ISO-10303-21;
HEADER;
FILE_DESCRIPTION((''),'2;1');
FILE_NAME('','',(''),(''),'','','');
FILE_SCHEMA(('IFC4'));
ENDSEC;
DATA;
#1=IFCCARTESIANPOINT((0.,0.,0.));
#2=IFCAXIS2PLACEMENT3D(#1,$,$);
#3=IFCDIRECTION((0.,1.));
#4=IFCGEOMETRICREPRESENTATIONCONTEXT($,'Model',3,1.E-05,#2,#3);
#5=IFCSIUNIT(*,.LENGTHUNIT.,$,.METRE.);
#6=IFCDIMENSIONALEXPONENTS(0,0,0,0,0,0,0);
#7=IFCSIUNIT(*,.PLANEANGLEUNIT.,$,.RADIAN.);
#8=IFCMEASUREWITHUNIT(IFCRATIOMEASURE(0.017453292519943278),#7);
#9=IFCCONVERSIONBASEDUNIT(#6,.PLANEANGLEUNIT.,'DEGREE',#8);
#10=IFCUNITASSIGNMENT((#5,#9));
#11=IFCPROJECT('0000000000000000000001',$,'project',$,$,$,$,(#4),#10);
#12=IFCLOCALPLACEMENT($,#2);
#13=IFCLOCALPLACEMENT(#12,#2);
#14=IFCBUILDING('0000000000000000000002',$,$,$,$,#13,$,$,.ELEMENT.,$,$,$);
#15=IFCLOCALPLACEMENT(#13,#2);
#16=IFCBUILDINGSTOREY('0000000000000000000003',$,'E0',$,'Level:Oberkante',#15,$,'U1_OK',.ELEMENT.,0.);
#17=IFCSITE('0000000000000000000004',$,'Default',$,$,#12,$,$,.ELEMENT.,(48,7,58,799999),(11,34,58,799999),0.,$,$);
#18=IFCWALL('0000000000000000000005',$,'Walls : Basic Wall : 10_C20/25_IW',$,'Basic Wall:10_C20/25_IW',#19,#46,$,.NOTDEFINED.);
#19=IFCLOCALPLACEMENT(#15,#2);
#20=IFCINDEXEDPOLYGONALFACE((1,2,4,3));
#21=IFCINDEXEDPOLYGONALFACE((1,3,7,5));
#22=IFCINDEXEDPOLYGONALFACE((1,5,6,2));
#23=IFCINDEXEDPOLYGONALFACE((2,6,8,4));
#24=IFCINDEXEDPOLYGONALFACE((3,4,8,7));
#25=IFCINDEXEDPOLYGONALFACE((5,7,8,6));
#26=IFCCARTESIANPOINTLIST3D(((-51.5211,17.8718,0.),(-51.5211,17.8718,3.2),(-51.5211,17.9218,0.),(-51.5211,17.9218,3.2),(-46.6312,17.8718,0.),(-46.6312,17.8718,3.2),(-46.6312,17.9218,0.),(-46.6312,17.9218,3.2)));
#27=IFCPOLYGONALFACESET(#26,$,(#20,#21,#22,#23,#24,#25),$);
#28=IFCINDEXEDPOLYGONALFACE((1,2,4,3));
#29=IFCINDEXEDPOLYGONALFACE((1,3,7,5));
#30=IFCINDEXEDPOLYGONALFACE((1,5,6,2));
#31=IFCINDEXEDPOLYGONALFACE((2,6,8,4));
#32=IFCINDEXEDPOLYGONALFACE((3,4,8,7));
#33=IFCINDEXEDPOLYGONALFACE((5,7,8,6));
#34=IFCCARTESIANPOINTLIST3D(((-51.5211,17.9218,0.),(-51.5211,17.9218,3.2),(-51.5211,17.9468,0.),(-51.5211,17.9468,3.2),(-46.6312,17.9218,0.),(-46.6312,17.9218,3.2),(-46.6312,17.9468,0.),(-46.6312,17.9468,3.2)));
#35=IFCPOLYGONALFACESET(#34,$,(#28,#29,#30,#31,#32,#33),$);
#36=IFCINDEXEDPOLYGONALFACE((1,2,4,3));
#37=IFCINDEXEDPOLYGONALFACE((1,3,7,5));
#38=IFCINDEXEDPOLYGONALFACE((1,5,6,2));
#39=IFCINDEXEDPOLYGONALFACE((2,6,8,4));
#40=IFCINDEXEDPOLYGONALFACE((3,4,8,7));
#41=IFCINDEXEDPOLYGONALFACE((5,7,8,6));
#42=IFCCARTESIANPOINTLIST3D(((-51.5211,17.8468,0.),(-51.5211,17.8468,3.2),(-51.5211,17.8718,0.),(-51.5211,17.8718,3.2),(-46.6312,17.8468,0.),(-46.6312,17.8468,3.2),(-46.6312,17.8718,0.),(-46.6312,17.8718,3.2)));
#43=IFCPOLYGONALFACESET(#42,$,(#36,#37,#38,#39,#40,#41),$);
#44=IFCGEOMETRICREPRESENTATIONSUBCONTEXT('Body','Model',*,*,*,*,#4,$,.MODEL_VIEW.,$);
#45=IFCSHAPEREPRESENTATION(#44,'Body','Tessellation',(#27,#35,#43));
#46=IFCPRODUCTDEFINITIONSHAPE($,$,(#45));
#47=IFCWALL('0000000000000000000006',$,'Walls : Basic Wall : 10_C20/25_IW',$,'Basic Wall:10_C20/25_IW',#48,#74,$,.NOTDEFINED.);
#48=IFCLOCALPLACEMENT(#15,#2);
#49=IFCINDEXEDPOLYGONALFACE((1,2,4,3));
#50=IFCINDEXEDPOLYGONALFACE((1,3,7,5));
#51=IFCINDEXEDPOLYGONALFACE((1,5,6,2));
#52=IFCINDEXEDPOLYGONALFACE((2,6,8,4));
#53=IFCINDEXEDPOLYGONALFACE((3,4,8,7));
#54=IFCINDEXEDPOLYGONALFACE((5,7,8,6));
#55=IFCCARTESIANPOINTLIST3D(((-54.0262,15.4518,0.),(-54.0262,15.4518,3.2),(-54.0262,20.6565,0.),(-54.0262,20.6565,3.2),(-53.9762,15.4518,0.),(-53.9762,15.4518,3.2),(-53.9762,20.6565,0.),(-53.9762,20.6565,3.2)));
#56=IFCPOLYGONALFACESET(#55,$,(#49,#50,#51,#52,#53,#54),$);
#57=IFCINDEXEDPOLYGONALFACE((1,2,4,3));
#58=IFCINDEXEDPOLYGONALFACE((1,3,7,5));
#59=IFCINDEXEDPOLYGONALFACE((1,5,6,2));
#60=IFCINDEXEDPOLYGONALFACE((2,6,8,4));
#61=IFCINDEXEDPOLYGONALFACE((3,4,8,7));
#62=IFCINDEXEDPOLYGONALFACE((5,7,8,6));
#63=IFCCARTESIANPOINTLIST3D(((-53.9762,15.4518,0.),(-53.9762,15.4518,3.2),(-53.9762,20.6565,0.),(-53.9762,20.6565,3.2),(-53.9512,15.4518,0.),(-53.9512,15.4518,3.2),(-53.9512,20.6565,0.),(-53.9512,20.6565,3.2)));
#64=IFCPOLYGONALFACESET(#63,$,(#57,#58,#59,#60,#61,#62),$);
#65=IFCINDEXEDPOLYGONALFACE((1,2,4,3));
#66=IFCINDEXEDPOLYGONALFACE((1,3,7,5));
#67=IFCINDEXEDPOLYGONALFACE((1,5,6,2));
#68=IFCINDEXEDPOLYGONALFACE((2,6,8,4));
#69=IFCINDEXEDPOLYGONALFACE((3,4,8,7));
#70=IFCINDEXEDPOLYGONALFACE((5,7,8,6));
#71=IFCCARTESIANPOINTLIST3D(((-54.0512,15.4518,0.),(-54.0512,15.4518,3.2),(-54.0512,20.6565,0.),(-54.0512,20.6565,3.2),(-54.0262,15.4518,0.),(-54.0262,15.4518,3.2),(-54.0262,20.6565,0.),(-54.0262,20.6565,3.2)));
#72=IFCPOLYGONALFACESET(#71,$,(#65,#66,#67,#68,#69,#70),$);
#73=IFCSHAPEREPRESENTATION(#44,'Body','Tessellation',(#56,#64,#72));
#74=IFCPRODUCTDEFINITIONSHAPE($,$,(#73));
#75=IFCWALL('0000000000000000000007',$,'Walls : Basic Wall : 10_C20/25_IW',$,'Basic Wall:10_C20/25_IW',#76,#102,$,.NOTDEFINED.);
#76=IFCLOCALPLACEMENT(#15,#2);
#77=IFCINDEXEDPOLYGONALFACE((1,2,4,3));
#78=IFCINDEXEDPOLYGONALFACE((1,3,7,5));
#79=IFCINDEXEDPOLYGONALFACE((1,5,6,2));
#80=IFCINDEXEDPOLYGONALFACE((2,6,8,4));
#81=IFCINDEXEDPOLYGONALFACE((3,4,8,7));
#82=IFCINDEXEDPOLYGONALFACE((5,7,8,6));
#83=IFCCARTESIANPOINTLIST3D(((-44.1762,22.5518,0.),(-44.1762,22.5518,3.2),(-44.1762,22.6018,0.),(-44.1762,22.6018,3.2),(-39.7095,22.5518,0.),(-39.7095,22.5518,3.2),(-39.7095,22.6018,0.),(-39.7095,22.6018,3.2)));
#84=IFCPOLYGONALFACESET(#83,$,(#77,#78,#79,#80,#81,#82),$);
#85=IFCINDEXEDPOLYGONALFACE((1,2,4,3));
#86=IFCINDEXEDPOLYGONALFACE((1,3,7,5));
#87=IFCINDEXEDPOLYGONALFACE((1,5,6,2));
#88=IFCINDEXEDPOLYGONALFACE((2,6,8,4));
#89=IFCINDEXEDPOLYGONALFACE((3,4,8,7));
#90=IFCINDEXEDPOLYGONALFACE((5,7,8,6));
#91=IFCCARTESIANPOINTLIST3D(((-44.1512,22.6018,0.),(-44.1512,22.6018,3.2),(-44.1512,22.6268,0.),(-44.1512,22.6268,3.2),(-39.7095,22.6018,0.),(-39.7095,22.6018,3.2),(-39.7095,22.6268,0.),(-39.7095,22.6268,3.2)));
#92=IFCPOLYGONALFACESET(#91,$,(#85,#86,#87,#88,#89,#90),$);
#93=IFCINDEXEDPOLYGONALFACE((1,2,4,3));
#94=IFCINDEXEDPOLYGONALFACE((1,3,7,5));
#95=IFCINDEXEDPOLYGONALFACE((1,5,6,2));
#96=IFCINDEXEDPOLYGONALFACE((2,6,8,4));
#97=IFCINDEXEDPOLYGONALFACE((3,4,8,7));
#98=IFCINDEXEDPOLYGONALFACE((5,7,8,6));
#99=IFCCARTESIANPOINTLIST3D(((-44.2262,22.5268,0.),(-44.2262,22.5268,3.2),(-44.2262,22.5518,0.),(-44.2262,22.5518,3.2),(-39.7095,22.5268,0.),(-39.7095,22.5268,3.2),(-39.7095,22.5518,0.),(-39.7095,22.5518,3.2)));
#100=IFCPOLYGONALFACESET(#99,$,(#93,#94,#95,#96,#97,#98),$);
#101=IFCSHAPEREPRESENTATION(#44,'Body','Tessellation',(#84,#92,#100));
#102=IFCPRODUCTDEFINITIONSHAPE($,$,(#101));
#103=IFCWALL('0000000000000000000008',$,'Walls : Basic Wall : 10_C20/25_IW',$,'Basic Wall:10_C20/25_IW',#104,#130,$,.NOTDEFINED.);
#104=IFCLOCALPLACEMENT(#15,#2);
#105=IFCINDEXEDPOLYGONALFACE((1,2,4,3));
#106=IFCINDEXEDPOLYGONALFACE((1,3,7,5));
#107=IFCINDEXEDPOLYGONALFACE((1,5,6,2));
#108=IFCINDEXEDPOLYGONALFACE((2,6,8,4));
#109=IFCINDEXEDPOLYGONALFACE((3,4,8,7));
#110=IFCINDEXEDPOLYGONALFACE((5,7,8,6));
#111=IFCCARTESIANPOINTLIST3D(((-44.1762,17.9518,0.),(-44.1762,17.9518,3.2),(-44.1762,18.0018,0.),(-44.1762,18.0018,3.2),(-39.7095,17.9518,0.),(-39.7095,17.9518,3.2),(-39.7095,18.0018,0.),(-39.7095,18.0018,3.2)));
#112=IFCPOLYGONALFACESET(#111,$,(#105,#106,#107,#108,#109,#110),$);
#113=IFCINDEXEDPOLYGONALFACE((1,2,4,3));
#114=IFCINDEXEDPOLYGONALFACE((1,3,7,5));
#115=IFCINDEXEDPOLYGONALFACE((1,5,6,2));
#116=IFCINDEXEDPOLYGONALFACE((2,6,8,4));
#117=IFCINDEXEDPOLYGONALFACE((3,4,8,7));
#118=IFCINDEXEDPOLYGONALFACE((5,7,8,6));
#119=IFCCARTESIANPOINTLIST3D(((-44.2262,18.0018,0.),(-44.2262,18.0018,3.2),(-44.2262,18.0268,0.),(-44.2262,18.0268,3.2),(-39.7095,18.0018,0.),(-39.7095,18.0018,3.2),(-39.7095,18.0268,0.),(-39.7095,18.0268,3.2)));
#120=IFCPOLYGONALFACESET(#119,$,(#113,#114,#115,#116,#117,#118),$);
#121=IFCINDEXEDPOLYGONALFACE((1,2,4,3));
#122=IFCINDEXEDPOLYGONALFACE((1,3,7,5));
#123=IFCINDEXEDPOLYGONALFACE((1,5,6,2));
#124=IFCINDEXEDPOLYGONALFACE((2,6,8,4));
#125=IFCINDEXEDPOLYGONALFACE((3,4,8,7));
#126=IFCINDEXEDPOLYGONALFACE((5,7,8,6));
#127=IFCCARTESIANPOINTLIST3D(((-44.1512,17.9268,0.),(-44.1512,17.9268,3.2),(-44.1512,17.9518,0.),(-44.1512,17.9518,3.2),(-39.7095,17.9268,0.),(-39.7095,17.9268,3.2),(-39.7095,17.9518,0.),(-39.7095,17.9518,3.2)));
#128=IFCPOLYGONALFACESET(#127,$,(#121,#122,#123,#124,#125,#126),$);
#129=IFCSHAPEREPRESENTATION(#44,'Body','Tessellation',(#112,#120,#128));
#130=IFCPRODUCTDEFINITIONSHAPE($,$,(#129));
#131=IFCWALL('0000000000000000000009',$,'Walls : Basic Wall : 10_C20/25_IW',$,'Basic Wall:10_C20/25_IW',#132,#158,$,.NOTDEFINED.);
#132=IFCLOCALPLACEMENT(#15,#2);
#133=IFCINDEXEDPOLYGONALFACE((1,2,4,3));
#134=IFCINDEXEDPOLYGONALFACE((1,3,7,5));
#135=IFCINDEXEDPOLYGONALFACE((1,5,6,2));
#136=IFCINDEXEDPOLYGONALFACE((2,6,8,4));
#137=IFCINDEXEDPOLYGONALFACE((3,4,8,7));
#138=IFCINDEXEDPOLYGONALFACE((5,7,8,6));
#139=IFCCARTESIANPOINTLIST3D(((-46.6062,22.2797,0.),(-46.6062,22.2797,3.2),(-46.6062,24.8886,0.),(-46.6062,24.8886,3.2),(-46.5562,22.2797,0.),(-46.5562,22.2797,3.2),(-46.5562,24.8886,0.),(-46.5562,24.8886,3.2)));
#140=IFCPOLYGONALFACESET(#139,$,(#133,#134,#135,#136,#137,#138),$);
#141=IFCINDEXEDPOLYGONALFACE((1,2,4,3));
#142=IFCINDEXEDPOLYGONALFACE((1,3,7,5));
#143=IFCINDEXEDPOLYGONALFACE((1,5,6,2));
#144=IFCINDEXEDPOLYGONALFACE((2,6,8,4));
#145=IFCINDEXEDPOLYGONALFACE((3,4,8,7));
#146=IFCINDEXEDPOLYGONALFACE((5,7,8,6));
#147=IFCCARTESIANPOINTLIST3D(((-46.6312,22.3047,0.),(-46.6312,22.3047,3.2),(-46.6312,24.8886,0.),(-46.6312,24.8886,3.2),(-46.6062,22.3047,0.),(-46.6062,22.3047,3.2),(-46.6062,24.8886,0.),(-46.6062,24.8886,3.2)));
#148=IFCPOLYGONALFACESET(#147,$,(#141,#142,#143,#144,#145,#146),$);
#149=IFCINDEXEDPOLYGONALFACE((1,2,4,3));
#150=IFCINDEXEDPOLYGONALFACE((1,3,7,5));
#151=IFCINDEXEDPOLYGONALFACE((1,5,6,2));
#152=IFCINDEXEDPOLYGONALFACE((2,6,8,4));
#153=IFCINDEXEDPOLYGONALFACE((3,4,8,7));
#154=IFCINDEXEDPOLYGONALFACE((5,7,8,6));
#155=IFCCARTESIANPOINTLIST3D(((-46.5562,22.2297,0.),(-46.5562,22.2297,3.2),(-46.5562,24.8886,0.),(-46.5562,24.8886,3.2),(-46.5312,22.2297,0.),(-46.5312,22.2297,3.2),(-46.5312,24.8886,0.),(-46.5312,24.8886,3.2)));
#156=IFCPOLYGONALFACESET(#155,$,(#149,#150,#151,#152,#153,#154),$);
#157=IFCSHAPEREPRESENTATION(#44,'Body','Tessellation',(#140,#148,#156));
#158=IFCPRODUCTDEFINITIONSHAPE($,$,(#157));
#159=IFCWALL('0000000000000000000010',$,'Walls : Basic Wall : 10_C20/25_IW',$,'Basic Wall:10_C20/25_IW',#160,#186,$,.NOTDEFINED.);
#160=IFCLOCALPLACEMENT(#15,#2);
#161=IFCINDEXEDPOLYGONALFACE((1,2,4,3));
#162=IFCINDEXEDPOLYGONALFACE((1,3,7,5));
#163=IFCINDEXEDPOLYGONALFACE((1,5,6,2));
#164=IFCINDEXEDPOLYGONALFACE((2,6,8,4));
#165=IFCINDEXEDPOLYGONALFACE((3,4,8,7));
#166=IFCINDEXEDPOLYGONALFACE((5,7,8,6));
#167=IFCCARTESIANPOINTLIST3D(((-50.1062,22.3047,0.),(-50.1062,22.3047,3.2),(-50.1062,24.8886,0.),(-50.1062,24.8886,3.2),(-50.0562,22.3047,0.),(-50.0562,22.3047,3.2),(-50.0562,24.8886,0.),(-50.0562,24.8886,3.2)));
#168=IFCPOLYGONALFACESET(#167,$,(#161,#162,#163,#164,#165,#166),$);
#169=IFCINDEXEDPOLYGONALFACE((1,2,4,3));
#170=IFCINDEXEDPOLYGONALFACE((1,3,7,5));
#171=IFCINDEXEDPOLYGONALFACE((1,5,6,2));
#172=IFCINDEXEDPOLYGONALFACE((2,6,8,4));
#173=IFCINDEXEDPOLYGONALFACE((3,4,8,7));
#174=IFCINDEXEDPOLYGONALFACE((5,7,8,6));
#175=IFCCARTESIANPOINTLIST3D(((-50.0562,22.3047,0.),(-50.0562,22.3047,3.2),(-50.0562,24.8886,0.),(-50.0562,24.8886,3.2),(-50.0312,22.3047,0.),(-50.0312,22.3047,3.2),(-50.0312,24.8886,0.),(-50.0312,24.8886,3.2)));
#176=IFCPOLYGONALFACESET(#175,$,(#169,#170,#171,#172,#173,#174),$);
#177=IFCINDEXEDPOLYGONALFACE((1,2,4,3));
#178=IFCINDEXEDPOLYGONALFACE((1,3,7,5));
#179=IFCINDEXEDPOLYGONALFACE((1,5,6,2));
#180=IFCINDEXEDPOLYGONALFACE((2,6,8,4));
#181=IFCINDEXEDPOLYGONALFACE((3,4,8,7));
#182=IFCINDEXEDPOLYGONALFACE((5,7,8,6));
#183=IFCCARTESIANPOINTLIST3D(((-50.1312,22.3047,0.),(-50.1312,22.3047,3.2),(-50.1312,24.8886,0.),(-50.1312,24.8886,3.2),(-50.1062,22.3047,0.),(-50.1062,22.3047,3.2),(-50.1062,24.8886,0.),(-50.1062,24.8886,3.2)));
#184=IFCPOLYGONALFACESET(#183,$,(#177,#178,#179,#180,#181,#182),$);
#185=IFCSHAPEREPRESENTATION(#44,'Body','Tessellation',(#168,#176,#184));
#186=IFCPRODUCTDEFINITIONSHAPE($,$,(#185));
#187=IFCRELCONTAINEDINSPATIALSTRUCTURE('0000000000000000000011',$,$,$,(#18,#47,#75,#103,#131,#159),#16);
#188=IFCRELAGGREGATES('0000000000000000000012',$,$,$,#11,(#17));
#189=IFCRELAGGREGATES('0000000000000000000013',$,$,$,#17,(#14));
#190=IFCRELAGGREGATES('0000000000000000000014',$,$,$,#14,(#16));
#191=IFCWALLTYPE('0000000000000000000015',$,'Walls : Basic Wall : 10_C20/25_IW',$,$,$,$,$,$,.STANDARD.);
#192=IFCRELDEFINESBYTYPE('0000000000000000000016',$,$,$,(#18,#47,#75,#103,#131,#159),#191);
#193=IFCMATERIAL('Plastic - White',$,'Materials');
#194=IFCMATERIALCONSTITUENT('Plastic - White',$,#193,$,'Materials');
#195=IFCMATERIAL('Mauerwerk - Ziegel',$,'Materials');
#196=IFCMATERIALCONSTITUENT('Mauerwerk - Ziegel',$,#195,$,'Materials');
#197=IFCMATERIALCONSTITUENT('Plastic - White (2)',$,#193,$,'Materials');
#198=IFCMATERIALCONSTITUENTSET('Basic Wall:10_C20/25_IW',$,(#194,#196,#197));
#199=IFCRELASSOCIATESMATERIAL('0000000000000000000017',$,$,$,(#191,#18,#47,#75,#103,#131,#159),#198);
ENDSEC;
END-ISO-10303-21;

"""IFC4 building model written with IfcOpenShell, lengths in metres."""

from ifc_helpers import new_model, entity, si_unit, converted_unit, direction, frame, origin, place, context, subcontext, project, spatial, indexed_curve, outline, extrude, material, constituent, constituent_set, type_object, element, save


model = new_model("IFC4")

# Units and contexts
model_context = context("Model", 3, precision=1e-05, world=origin(), true_north=direction((0.0, 1.0)))
body_context = subcontext(model_context, "Body", "Model", "MODEL_VIEW")
ifc_project = project(units=[si_unit("LENGTHUNIT", "METRE"), converted_unit("PLANEANGLEUNIT", "DEGREE", entity("IfcRatioMeasure", 0.017453292519943278), si_unit("PLANEANGLEUNIT", "RADIAN"), dimensions=[0, 0, 0, 0, 0, 0, 0])], contexts=[model_context])

# Site, building, storey
site_placement = place(None, origin())
site = spatial("IfcSite", under=ifc_project, at=site_placement, Name="Default", CompositionType="ELEMENT", RefLatitude=(48, 7, 58, 799999), RefLongitude=(11, 34, 58, 799999), RefElevation=0.0)
building_placement = place(site_placement, origin())
building = spatial("IfcBuilding", under=site, at=building_placement, CompositionType="ELEMENT")
storey_placement = place(building_placement, origin())
storey = spatial("IfcBuildingStorey", under=building, at=storey_placement, Name="E0", ObjectType="Level:Oberkante", LongName="U1_OK", CompositionType="ELEMENT", Elevation=0.0)

# Wall
ifc_material_1 = material(Name="Plastic - White", Category="Materials")
ifc_constituent_1 = constituent(ifc_material_1, Name="Plastic - White", Category="Materials")
ifc_material_2 = material(Name="Mauerwerk - Ziegel", Category="Materials")
ifc_constituent_2 = constituent(ifc_material_2, Name="Mauerwerk - Ziegel", Category="Materials")
ifc_constituent_3 = constituent(ifc_material_1, Name="Plastic - White (2)", Category="Materials")
ifc_constituent_set_1 = constituent_set(constituents=[ifc_constituent_1, ifc_constituent_2, ifc_constituent_3], Name="Basic Wall:10_C20/25_IW")
wall_type_1 = type_object("IfcWallType", Name="Walls : Basic Wall : 10_C20/25_IW", PredefinedType="STANDARD", material=ifc_constituent_set_1)
wall_1_placement = place(storey_placement, frame((-51.5211, 17.8968, 0.0)))
element("IfcWall", 1, at=wall_1_placement, inside=storey, type_object=wall_type_1, material=ifc_constituent_set_1, Name="Walls : Basic Wall : 10_C20/25_IW", ObjectType="Basic Wall:10_C20/25_IW", PredefinedType="NOTDEFINED", context=body_context, shape_type="SweptSolid", body=[
    extrude(outline(indexed_curve([(-2.4449, -0.025), (2.4449, -0.025), (2.4449, 0.025), (-2.4449, 0.025), (-2.4449, -0.025)], self_intersect=False)), frame((2.4449, 0.0, 0.0)), (0.0, 0.0, 1.0), 3.2),
    extrude(outline(indexed_curve([(-0.0125, -2.4449), (0.0125, -2.4449), (0.0125, 2.4449), (-0.0125, 2.4449), (-0.0125, -2.4449)], self_intersect=False)), frame((2.4449, 0.0375, 0.0), z_axis=(0.0, 0.0, 1.0), x_axis=(0.0, -1.0, 0.0)), (0.0, 0.0, 1.0), 3.2),
    extrude(outline(indexed_curve([(-0.0125, -2.4449), (0.0125, -2.4449), (0.0125, 2.4449), (-0.0125, 2.4449), (-0.0125, -2.4449)], self_intersect=False)), frame((2.4449, -0.0375, 0.0), z_axis=(0.0, 0.0, 1.0), x_axis=(0.0, 1.0, 0.0)), (0.0, 0.0, 1.0), 3.2),
])

# Wall
wall_2_placement = place(storey_placement, frame((-54.0012, 20.6565, 0.0), z_axis=(0.0, 0.0, 1.0), x_axis=(0.0, -1.0, 0.0)))
element("IfcWall", 2, at=wall_2_placement, inside=storey, type_object=wall_type_1, material=ifc_constituent_set_1, Name="Walls : Basic Wall : 10_C20/25_IW", ObjectType="Basic Wall:10_C20/25_IW", PredefinedType="NOTDEFINED", context=body_context, shape_type="SweptSolid", body=[
    extrude(outline(indexed_curve([(-2.6024, -0.025), (2.6024, -0.025), (2.6024, 0.025), (-2.6024, 0.025), (-2.6024, -0.025)], self_intersect=False)), frame((2.6024, 0.0, 0.0)), (0.0, 0.0, 1.0), 3.2),
    extrude(outline(indexed_curve([(-0.0125, -2.6024), (0.0125, -2.6024), (0.0125, 2.6024), (-0.0125, 2.6024), (-0.0125, -2.6024)], self_intersect=False)), frame((2.6024, 0.0375, 0.0), z_axis=(0.0, 0.0, 1.0), x_axis=(0.0, -1.0, 0.0)), (0.0, 0.0, 1.0), 3.2),
    extrude(outline(indexed_curve([(-0.0125, -2.6024), (0.0125, -2.6024), (0.0125, 2.6024), (-0.0125, 2.6024), (-0.0125, -2.6024)], self_intersect=False)), frame((2.6024, -0.0375, 0.0), z_axis=(0.0, 0.0, 1.0), x_axis=(0.0, 1.0, 0.0)), (0.0, 0.0, 1.0), 3.2),
])

# Walls
wall_3_placement = place(storey_placement, frame((-44.1512, 22.5768, 0.0)))
element("IfcWall", 3, at=wall_3_placement, inside=storey, type_object=wall_type_1, material=ifc_constituent_set_1, Name="Walls : Basic Wall : 10_C20/25_IW", ObjectType="Basic Wall:10_C20/25_IW", PredefinedType="NOTDEFINED", context=body_context, shape_type="SweptSolid", body=[
    extrude(outline(indexed_curve([(-2.2334, -0.025), (2.2334, -0.025), (2.2334, 0.025), (-2.2334, 0.025), (-2.2334, -0.025)], self_intersect=False)), frame((2.2084, 0.0, 0.0)), (0.0, 0.0, 1.0), 3.2),
    extrude(outline(indexed_curve([(-0.0125, -2.2209), (0.0125, -2.2209), (0.0125, 2.2209), (-0.0125, 2.2209), (-0.0125, -2.2209)], self_intersect=False)), frame((2.2209, 0.0375, 0.0), z_axis=(0.0, 0.0, 1.0), x_axis=(0.0, -1.0, 0.0)), (0.0, 0.0, 1.0), 3.2),
    extrude(outline(indexed_curve([(-0.0125, -2.2584), (0.0125, -2.2584), (0.0125, 2.2584), (-0.0125, 2.2584), (-0.0125, -2.2584)], self_intersect=False)), frame((2.1834, -0.0375, 0.0), z_axis=(0.0, 0.0, 1.0), x_axis=(0.0, 1.0, 0.0)), (0.0, 0.0, 1.0), 3.2),
])
wall_4_placement = place(storey_placement, frame((-44.1512, 17.9768, 0.0)))
element("IfcWall", 4, at=wall_4_placement, inside=storey, type_object=wall_type_1, material=ifc_constituent_set_1, Name="Walls : Basic Wall : 10_C20/25_IW", ObjectType="Basic Wall:10_C20/25_IW", PredefinedType="NOTDEFINED", context=body_context, shape_type="SweptSolid", body=[
    extrude(outline(indexed_curve([(-2.2334, -0.025), (2.2334, -0.025), (2.2334, 0.025), (-2.2334, 0.025), (-2.2334, -0.025)], self_intersect=False)), frame((2.2084, 0.0, 0.0)), (0.0, 0.0, 1.0), 3.2),
    extrude(outline(indexed_curve([(-0.0125, -2.2584), (0.0125, -2.2584), (0.0125, 2.2584), (-0.0125, 2.2584), (-0.0125, -2.2584)], self_intersect=False)), frame((2.1834, 0.0375, 0.0), z_axis=(0.0, 0.0, 1.0), x_axis=(0.0, -1.0, 0.0)), (0.0, 0.0, 1.0), 3.2),
    extrude(outline(indexed_curve([(-0.0125, -2.2209), (0.0125, -2.2209), (0.0125, 2.2209), (-0.0125, 2.2209), (-0.0125, -2.2209)], self_intersect=False)), frame((2.2209, -0.0375, 0.0), z_axis=(0.0, 0.0, 1.0), x_axis=(0.0, 1.0, 0.0)), (0.0, 0.0, 1.0), 3.2),
])

# Walls
wall_5_placement = place(storey_placement, frame((-46.5812, 22.3047, 0.0), z_axis=(0.0, 0.0, 1.0), x_axis=(0.0, 1.0, 0.0)))
element("IfcWall", 5, at=wall_5_placement, inside=storey, type_object=wall_type_1, material=ifc_constituent_set_1, Name="Walls : Basic Wall : 10_C20/25_IW", ObjectType="Basic Wall:10_C20/25_IW", PredefinedType="NOTDEFINED", context=body_context, shape_type="SweptSolid", body=[
    extrude(outline(indexed_curve([(-1.3045, -0.025), (1.3045, -0.025), (1.3045, 0.025), (-1.3045, 0.025), (-1.3045, -0.025)], self_intersect=False)), frame((1.2795, 0.0, 0.0)), (0.0, 0.0, 1.0), 3.2),
    extrude(outline(indexed_curve([(-0.0125, -1.292), (0.0125, -1.292), (0.0125, 1.292), (-0.0125, 1.292), (-0.0125, -1.292)], self_intersect=False)), frame((1.292, 0.0375, 0.0), z_axis=(0.0, 0.0, 1.0), x_axis=(0.0, -1.0, 0.0)), (0.0, 0.0, 1.0), 3.2),
    extrude(outline(indexed_curve([(-0.0125, -1.3295), (0.0125, -1.3295), (0.0125, 1.3295), (-0.0125, 1.3295), (-0.0125, -1.3295)], self_intersect=False)), frame((1.2545, -0.0375, 0.0), z_axis=(0.0, 0.0, 1.0), x_axis=(0.0, 1.0, 0.0)), (0.0, 0.0, 1.0), 3.2),
])
wall_6_placement = place(storey_placement, frame((-50.0812, 24.8886, 0.0), z_axis=(0.0, 0.0, 1.0), x_axis=(0.0, -1.0, 0.0)))
element("IfcWall", 6, at=wall_6_placement, inside=storey, type_object=wall_type_1, material=ifc_constituent_set_1, Name="Walls : Basic Wall : 10_C20/25_IW", ObjectType="Basic Wall:10_C20/25_IW", PredefinedType="NOTDEFINED", context=body_context, shape_type="SweptSolid", body=[
    extrude(outline(indexed_curve([(-1.292, -0.025), (1.292, -0.025), (1.292, 0.025), (-1.292, 0.025), (-1.292, -0.025)], self_intersect=False)), frame((1.292, 0.0, 0.0)), (0.0, 0.0, 1.0), 3.2),
    extrude(outline(indexed_curve([(-0.0125, -1.292), (0.0125, -1.292), (0.0125, 1.292), (-0.0125, 1.292), (-0.0125, -1.292)], self_intersect=False)), frame((1.292, 0.0375, 0.0), z_axis=(0.0, 0.0, 1.0), x_axis=(0.0, -1.0, 0.0)), (0.0, 0.0, 1.0), 3.2),
    extrude(outline(indexed_curve([(-0.0125, -1.292), (0.0125, -1.292), (0.0125, 1.292), (-0.0125, 1.292), (-0.0125, -1.292)], self_intersect=False)), frame((1.292, -0.0375, 0.0), z_axis=(0.0, 0.0, 1.0), x_axis=(0.0, 1.0, 0.0)), (0.0, 0.0, 1.0), 3.2),
])

save(model, "model.ifc")
